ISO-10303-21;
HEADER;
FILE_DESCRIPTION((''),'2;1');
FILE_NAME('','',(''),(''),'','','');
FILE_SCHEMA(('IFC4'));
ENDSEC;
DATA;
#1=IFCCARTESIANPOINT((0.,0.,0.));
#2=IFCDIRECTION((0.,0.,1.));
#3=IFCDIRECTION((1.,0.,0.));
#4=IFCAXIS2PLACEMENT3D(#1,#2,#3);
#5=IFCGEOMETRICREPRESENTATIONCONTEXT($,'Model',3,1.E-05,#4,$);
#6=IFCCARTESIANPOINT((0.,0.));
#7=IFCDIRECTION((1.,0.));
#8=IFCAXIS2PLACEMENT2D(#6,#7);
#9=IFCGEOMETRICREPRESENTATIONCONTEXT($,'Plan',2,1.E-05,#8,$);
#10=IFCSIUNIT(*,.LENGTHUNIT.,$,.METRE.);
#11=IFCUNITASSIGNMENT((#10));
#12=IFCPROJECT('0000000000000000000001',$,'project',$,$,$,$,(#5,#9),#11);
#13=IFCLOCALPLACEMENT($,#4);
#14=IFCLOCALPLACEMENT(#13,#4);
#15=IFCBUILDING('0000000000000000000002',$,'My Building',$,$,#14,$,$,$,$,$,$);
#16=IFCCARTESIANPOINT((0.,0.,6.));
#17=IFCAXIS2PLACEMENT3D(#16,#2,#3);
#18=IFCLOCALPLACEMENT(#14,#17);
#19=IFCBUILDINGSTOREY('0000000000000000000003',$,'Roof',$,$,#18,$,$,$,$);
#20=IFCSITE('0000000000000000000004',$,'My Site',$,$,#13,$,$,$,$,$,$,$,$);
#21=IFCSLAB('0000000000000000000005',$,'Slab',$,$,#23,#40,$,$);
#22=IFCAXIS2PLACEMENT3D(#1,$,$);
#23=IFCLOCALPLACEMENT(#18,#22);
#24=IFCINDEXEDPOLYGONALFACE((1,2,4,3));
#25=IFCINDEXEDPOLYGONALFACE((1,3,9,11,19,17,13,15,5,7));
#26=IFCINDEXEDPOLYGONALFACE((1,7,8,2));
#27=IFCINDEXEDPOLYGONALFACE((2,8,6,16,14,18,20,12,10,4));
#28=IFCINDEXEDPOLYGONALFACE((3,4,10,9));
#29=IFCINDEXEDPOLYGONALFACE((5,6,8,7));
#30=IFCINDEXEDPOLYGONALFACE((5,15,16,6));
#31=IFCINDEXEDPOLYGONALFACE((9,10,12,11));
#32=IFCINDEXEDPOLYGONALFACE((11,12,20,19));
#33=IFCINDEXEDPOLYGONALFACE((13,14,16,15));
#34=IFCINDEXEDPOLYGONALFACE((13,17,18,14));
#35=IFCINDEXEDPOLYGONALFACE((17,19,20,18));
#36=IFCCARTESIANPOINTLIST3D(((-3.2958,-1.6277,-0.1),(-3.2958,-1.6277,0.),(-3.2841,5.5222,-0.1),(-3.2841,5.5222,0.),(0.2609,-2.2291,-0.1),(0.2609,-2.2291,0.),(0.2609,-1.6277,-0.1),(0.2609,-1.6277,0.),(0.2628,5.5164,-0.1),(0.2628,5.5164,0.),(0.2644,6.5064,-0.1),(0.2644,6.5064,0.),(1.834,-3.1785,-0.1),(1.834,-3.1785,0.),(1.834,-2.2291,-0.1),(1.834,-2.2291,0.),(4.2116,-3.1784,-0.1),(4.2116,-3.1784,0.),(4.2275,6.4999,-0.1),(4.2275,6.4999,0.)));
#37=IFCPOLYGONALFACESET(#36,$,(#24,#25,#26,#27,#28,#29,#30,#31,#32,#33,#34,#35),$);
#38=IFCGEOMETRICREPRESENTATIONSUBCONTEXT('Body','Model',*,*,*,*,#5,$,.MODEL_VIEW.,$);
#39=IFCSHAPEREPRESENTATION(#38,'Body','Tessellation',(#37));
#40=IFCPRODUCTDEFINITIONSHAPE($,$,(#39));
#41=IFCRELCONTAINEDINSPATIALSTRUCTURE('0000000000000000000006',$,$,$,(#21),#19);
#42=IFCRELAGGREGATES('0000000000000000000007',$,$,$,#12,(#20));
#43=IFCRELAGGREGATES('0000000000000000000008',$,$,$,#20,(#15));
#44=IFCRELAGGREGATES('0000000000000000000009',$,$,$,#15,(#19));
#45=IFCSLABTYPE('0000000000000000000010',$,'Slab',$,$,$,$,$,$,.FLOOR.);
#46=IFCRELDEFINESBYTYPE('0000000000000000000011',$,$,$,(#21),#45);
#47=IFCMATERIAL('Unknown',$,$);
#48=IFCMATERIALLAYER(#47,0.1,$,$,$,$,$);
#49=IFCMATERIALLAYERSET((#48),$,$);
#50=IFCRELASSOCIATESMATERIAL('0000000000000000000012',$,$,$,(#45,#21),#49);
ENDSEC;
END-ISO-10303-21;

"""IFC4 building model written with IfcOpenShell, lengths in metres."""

from ifc_helpers import new_model, si_unit, frame, origin_with_axes, origin_2d_with_axis, place, context, subcontext, project, spatial, indexed_curve, outline, extrude, material, layer, layer_set, layer_usage, type_object, element, save


model = new_model("IFC4")

# Units and contexts
model_context = context("Model", 3, precision=1e-05, world=origin_with_axes())
plan_context = context("Plan", 2, precision=1e-05, world=origin_2d_with_axis())
body_context = subcontext(model_context, "Body", "Model", "MODEL_VIEW")
ifc_project = project(units=[si_unit("LENGTHUNIT", "METRE")], contexts=[model_context, plan_context])

# Site, building, storey
site_placement = place(None, origin_with_axes())
site = spatial("IfcSite", under=ifc_project, at=site_placement, Name="My Site")
building_placement = place(site_placement, origin_with_axes())
building = spatial("IfcBuilding", under=site, at=building_placement, Name="My Building")
storey_placement = place(building_placement, frame((0.0, 0.0, 6.0), z_axis=(0.0, 0.0, 1.0), x_axis=(1.0, 0.0, 0.0)))
storey = spatial("IfcBuildingStorey", under=building, at=storey_placement, Name="Roof")

# Slab
ifc_material = material(Name="Unknown")
ifc_layer = layer(ifc_material, 0.1)
ifc_layer_set = layer_set([ifc_layer])
ifc_layer_usage = layer_usage(ifc_layer_set, "AXIS3", "POSITIVE", -0.1)
slab_type = type_object("IfcSlabType", Name="Slab", PredefinedType="FLOOR", material=ifc_layer_set)
slab_placement = place(storey_placement, frame((4.2116, -3.1784, 0.0), z_axis=(0.0, 0.0, 1.0), x_axis=(1.0, 0.0, 0.0)))
element("IfcSlab", 1, at=slab_placement, inside=storey, type_object=slab_type, material=ifc_layer_usage, Name="Slab", context=body_context, shape_type="SweptSolid", body=[
    extrude(outline(indexed_curve([(0.0, 0.0), (0.0159, 9.6783), (-3.9472, 9.6848), (-3.9489, 8.6948), (-7.4957, 8.7006), (-7.5075, 1.5506), (-3.9508, 1.5506), (-3.9508, 0.9493), (-2.3776, 0.9493), (-2.3776, -0.0001), (0.0, 0.0)])), frame((0.0, 0.0, -0.1), z_axis=(0.0, 0.0, 1.0), x_axis=(1.0, 0.0, 0.0)), (0.0, 0.0, 1.0), 0.1),
])

save(model, "model.ifc")
